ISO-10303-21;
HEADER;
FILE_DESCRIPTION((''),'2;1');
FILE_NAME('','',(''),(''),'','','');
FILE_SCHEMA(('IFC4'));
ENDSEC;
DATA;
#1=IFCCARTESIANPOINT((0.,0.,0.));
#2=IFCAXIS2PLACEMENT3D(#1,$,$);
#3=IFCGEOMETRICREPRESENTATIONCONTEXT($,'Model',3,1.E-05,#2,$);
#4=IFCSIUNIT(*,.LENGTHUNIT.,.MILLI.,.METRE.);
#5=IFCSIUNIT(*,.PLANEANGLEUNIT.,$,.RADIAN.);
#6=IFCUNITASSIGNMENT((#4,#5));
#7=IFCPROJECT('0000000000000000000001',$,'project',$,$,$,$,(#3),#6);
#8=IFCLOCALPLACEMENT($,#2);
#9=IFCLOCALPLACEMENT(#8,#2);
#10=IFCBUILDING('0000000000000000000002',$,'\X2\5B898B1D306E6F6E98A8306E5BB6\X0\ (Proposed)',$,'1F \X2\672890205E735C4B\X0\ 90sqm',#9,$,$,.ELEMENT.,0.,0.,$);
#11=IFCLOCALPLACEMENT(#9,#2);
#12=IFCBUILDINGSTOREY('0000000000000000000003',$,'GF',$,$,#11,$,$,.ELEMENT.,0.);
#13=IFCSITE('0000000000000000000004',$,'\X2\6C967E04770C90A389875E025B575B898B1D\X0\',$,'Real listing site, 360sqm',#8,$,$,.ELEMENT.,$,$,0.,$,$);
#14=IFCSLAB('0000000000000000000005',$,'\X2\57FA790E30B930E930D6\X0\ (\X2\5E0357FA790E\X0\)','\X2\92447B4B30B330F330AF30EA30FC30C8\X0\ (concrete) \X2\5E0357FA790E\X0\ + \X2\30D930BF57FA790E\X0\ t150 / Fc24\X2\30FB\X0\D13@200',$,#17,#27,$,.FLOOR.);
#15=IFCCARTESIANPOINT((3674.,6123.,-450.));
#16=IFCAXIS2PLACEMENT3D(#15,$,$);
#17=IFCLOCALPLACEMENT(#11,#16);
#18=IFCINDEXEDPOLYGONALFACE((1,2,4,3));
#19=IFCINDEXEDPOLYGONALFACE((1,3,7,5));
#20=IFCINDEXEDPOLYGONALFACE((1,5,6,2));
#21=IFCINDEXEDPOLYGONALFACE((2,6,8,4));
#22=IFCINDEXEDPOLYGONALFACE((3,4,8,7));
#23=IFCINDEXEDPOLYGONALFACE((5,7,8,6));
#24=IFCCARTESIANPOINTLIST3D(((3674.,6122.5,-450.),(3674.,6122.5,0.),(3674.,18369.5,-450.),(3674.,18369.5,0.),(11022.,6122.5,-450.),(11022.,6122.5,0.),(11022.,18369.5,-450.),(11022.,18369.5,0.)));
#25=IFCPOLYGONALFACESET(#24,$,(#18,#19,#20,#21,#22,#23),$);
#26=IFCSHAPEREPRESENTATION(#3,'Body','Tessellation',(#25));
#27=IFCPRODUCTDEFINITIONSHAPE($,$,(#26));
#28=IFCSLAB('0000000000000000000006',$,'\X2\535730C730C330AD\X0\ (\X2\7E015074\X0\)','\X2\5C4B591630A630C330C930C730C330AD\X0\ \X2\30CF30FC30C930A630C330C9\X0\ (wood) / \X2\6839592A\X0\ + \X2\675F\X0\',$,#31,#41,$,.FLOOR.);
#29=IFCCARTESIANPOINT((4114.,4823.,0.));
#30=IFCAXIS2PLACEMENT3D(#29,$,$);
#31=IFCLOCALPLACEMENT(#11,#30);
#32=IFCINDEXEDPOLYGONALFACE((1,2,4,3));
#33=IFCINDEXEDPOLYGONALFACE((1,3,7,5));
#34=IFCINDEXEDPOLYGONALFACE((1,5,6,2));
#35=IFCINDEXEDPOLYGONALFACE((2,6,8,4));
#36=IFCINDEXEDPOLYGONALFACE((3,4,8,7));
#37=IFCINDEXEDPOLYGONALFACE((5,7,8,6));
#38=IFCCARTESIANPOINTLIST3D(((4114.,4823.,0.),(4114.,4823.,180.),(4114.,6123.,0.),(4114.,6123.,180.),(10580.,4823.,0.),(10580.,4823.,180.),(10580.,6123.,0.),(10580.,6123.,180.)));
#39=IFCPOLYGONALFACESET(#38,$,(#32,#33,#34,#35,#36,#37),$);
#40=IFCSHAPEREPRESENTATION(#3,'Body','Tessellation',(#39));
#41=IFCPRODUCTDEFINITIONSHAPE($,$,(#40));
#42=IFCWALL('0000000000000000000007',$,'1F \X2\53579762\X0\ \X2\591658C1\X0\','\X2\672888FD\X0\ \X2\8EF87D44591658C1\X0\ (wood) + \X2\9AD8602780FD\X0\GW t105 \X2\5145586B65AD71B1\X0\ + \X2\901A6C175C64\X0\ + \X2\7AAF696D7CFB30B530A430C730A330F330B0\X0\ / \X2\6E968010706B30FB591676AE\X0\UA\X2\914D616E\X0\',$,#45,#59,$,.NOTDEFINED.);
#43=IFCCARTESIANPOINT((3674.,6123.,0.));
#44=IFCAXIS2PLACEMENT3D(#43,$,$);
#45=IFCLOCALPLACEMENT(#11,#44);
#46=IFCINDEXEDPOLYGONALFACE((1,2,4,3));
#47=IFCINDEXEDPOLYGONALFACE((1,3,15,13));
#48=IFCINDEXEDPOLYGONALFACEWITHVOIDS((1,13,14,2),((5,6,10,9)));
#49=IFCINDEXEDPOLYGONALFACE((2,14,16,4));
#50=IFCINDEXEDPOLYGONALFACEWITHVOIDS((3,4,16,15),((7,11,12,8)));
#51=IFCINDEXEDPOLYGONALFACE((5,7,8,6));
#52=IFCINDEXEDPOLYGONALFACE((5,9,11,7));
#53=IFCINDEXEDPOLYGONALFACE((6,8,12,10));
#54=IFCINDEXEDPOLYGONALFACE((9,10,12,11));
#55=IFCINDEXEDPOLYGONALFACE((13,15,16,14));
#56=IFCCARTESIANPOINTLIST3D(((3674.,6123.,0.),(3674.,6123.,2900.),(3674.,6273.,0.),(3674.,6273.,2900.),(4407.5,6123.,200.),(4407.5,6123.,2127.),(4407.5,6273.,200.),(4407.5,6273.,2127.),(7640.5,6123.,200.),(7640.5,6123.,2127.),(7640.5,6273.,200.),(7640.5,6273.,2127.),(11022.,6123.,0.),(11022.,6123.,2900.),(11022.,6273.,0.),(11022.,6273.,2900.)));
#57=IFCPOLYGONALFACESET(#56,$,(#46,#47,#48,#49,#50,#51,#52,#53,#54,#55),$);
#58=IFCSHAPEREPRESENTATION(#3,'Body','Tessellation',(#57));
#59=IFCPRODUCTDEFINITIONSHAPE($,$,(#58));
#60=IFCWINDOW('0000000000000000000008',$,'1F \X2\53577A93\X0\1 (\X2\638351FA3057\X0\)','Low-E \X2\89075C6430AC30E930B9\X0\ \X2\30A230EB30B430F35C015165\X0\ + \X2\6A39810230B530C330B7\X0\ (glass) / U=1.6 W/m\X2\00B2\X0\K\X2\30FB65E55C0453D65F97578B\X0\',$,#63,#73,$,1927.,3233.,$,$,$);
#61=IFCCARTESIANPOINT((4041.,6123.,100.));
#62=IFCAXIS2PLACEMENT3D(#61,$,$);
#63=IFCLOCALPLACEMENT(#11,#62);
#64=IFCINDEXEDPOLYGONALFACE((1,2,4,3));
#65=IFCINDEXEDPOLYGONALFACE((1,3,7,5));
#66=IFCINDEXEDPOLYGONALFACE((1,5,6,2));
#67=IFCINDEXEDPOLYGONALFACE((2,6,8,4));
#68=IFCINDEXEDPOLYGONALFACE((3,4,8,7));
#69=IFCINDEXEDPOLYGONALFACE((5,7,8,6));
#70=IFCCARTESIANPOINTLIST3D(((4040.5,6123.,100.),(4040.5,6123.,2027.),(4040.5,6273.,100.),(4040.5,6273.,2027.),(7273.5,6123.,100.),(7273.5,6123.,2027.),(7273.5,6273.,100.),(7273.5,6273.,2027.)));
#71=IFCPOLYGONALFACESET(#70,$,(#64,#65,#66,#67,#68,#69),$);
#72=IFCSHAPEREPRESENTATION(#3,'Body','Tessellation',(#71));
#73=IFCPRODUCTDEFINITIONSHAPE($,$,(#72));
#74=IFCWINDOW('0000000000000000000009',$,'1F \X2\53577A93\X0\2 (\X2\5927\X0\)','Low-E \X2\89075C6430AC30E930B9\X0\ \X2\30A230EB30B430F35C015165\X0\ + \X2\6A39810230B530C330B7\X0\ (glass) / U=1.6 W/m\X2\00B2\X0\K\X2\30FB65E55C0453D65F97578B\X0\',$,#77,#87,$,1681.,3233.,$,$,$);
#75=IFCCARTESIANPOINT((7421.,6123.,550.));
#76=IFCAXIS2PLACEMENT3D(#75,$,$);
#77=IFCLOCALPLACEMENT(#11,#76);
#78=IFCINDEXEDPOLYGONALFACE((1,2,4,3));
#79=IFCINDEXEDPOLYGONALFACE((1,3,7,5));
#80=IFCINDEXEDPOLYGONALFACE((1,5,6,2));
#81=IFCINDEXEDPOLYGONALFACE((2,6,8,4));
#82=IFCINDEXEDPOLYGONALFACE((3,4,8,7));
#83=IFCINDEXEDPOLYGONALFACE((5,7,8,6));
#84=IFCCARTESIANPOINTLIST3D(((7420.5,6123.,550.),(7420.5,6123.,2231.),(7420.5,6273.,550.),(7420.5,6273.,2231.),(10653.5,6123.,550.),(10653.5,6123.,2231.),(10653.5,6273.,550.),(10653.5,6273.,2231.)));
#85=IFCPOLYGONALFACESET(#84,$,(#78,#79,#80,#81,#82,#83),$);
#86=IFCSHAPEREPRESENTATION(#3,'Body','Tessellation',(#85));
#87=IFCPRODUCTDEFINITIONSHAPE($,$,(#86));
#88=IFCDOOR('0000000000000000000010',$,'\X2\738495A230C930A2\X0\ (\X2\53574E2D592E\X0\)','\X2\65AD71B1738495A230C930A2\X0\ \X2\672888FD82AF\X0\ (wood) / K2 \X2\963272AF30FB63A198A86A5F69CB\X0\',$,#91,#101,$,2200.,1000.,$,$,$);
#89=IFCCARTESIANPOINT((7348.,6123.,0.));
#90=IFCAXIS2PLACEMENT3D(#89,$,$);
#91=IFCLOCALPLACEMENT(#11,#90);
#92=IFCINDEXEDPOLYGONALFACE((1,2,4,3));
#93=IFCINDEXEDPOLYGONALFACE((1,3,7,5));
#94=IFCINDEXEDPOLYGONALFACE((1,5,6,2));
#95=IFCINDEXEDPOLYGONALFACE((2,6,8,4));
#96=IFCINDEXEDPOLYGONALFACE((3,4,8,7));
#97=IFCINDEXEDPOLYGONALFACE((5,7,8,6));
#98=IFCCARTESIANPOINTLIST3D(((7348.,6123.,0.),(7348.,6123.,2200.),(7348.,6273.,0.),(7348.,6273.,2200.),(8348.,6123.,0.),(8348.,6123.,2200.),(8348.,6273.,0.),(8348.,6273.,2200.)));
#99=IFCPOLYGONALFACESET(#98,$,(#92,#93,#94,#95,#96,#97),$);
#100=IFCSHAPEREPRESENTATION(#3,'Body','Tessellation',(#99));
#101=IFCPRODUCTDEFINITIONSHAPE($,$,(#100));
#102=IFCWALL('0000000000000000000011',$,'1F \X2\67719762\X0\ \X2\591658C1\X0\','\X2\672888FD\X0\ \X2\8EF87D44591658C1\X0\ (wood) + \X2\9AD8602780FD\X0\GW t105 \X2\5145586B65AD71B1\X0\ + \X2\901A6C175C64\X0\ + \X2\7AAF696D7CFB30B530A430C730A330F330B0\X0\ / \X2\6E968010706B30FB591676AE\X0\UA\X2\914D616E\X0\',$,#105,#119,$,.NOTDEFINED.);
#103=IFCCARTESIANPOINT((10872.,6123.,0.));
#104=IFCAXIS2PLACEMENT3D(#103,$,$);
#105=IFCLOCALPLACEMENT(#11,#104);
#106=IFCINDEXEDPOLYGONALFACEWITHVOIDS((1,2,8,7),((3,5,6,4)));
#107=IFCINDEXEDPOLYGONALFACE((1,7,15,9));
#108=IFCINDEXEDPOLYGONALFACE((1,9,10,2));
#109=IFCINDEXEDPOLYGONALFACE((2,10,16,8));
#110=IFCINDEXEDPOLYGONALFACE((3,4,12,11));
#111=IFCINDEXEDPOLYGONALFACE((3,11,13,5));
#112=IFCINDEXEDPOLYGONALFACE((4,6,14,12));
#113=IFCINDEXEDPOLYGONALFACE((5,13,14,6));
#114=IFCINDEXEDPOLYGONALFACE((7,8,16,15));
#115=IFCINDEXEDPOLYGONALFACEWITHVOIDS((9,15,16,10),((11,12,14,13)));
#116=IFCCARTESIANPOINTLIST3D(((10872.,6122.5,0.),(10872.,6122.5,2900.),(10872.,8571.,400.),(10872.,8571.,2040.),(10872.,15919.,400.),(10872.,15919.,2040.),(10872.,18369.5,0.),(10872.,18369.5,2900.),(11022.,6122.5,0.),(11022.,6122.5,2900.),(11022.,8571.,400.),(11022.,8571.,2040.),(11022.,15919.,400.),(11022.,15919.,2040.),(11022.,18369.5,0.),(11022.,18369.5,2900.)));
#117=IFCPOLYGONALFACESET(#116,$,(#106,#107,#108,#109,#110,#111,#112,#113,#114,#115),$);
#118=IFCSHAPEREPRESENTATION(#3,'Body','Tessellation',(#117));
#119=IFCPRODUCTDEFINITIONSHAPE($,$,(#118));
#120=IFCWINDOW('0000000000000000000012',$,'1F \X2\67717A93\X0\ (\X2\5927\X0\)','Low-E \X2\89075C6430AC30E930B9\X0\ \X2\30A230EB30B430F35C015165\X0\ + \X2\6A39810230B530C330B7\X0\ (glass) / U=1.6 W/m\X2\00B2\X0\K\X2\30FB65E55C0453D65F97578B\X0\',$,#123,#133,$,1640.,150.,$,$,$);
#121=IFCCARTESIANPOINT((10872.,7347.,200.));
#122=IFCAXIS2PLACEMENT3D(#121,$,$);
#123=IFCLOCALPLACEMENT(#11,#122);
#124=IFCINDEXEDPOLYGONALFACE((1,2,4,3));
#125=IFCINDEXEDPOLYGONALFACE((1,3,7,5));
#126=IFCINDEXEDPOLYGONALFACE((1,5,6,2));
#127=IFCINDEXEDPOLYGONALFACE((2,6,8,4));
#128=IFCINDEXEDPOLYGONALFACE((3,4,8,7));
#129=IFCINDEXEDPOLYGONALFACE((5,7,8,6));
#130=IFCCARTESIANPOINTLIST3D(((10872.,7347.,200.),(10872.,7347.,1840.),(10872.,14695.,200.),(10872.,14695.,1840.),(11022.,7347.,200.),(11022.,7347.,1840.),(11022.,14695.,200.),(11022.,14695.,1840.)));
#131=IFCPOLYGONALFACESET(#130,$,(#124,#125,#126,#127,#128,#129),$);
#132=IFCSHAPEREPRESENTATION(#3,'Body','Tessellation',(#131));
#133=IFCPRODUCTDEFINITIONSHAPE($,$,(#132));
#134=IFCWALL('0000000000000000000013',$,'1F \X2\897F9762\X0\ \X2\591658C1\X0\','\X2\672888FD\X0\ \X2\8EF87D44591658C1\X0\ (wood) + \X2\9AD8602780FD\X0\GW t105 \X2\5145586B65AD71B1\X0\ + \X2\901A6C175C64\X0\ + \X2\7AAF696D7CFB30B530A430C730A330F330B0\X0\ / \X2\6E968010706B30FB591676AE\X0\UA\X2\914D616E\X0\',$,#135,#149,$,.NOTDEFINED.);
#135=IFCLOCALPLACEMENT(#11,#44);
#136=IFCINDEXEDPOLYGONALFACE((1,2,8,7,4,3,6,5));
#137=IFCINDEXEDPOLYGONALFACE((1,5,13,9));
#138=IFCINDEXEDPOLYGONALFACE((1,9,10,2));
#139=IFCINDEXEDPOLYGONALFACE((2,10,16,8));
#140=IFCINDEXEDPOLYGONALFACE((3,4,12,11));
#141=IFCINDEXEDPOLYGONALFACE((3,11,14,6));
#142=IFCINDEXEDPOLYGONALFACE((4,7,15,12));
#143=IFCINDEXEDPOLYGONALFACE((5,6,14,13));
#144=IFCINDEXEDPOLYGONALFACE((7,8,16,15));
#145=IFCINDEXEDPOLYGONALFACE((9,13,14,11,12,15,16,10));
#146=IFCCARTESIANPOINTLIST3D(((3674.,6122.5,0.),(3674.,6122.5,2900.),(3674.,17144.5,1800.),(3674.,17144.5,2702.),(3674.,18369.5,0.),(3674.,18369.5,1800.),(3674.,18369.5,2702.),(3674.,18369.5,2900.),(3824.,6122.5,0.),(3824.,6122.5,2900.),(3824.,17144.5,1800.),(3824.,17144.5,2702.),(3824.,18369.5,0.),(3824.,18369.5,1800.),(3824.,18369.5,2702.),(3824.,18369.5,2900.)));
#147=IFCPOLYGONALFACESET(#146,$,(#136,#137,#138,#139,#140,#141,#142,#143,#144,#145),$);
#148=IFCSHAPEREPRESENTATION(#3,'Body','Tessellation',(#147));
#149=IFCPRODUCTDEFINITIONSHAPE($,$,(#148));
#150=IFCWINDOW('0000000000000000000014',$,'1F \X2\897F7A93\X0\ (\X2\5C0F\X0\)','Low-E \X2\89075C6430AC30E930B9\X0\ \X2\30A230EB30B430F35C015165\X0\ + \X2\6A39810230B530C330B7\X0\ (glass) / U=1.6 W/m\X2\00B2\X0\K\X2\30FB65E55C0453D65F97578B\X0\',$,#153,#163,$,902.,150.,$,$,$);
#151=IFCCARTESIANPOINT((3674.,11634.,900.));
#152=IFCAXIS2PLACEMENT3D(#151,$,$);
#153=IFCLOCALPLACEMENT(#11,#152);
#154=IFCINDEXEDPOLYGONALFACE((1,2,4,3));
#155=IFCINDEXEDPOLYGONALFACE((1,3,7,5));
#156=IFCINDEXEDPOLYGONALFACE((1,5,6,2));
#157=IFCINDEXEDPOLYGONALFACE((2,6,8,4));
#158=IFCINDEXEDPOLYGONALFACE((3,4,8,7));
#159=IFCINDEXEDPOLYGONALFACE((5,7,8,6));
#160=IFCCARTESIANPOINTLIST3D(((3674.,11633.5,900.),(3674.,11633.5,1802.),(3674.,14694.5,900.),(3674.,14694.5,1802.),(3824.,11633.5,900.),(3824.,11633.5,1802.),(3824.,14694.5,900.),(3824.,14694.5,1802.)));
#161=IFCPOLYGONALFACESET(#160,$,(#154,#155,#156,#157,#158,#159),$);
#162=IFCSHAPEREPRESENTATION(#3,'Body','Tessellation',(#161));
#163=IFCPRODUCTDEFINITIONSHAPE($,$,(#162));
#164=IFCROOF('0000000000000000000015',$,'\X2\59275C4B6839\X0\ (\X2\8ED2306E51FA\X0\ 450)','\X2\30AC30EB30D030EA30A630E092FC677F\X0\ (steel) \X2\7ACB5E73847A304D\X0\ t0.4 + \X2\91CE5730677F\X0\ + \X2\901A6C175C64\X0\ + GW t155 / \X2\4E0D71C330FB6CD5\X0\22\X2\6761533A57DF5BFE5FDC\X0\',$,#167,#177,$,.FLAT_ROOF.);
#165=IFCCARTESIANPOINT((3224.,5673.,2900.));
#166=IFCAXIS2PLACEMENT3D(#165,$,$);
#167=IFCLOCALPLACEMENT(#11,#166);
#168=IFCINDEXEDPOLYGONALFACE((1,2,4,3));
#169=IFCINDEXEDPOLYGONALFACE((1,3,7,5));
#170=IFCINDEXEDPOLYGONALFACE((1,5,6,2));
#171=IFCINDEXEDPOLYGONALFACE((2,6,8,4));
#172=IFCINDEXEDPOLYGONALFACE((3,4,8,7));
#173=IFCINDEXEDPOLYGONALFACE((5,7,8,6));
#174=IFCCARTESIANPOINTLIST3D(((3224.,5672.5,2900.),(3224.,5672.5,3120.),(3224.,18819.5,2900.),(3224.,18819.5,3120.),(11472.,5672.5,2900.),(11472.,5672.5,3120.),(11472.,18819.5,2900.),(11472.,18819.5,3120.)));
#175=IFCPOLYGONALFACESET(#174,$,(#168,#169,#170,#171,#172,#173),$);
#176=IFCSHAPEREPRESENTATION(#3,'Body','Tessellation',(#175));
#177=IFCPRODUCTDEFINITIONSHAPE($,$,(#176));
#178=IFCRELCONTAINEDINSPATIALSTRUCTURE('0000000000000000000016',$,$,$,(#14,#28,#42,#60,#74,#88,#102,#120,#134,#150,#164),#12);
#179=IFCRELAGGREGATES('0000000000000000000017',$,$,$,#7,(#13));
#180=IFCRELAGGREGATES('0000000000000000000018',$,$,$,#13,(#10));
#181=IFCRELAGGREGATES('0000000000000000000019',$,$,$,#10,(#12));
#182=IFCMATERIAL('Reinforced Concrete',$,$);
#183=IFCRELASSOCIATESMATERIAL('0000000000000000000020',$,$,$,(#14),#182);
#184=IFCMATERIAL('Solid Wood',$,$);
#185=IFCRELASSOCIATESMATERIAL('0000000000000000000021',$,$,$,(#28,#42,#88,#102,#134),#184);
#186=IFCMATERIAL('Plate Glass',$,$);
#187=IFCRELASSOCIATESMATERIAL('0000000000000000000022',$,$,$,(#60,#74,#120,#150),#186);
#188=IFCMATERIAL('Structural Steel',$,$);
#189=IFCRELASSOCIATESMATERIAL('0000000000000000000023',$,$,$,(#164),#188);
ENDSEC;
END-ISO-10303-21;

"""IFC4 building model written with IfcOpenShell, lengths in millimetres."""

from ifc_helpers import new_model, si_unit, frame, frame_2d, origin, place, context, project, spatial, rectangle, extrude, material, element, fill, save


model = new_model("IFC4")

# Units and contexts
model_context = context("Model", 3, precision=1e-05, world=origin())
ifc_project = project(units=[si_unit("LENGTHUNIT", "METRE", prefix="MILLI"), si_unit("PLANEANGLEUNIT", "RADIAN")], contexts=[model_context])

# Site, building, storey
site_placement = place(None, origin())
site = spatial("IfcSite", under=ifc_project, at=site_placement, Name="沖縄県那覇市字安謝", ObjectType="Real listing site, 360sqm", CompositionType="ELEMENT", RefElevation=0.0)
building_placement = place(site_placement, origin())
building = spatial("IfcBuilding", under=site, at=building_placement, Name="安謝の潮風の家 (Proposed)", ObjectType="1F 木造平屋 90sqm", CompositionType="ELEMENT", ElevationOfRefHeight=0.0, ElevationOfTerrain=0.0)
storey_placement = place(building_placement, origin())
storey = spatial("IfcBuildingStorey", under=building, at=storey_placement, Name="GF", CompositionType="ELEMENT", Elevation=0.0)

# Slabs
ifc_material_1 = material(Name="Reinforced Concrete")
slab_1_placement = place(storey_placement, frame((3674.0, 6123.0, -450.0)))
element("IfcSlab", 1, at=slab_1_placement, inside=storey, material=ifc_material_1, Name="基礎スラブ (布基礎)", Description="鉄筋コンクリート (concrete) 布基礎 + ベタ基礎 t150 / Fc24・D13@200", PredefinedType="FLOOR", context=model_context, shape_type="SweptSolid", body=[
    extrude(rectangle(XDim=7348.0, YDim=12247.0, at=frame_2d((3674.0, 6123.0))), frame((3674.0, 6123.0, -450.0)), (0.0, 0.0, 1.0), 450.0),
])
ifc_material_2 = material(Name="Solid Wood")
slab_2_placement = place(storey_placement, frame((4114.0, 4823.0, 0.0)))
element("IfcSlab", 2, at=slab_2_placement, inside=storey, material=ifc_material_2, Name="南デッキ (縁側)", Description="屋外ウッドデッキ ハードウッド (wood) / 根太 + 束", PredefinedType="FLOOR", context=model_context, shape_type="SweptSolid", body=[
    extrude(rectangle(XDim=6466.0, YDim=1300.0, at=frame_2d((3233.0, 650.0))), frame((4114.0, 4823.0, 0.0)), (0.0, 0.0, 1.0), 180.0),
])

# Wall, openings, windows, door
wall_1_placement = place(storey_placement, frame((3674.0, 6123.0, 0.0)))
wall_1 = element("IfcWall", 3, at=wall_1_placement, inside=storey, material=ifc_material_2, Name="1F 南面 外壁", Description="木製 軸組外壁 (wood) + 高性能GW t105 充填断熱 + 通気層 + 窯業系サイディング / 準耐火・外皮UA配慮", PredefinedType="NOTDEFINED", context=model_context, shape_type="SweptSolid", body=[
    extrude(rectangle(XDim=7348.0, YDim=150.0, at=frame_2d((3674.0, 75.0))), frame((3674.0, 6123.0, 0.0)), (0.0, 0.0, 1.0), 2900.0),
])
opening_1_placement = place(storey_placement, frame((4041.0, 6123.0, 100.0)))
opening_1 = element("IfcOpeningElement", 4, at=opening_1_placement, cuts=wall_1, PredefinedType="NOTDEFINED", context=model_context, shape_type="SweptSolid", body=[
    extrude(rectangle(XDim=3233.0, YDim=150.0, at=frame_2d((1616.0, 75.0))), frame((4041.0, 6123.0, 100.0)), (0.0, 0.0, 1.0), 1927.0),
])
opening_2_placement = place(storey_placement, frame((7421.0, 6123.0, 550.0)))
opening_2 = element("IfcOpeningElement", 5, at=opening_2_placement, cuts=wall_1, PredefinedType="NOTDEFINED", context=model_context, shape_type="SweptSolid", body=[
    extrude(rectangle(XDim=3233.0, YDim=150.0, at=frame_2d((1616.0, 75.0))), frame((7421.0, 6123.0, 550.0)), (0.0, 0.0, 1.0), 1681.0),
])
opening_3_placement = place(storey_placement, frame((7348.0, 6123.0, 0.0)))
opening_3 = element("IfcOpeningElement", 6, at=opening_3_placement, cuts=wall_1, PredefinedType="NOTDEFINED", context=model_context, shape_type="SweptSolid", body=[
    extrude(rectangle(XDim=1000.0, YDim=150.0, at=frame_2d((500.0, 75.0))), frame((7348.0, 6123.0, 0.0)), (0.0, 0.0, 1.0), 2200.0),
])
ifc_material_3 = material(Name="Plate Glass")
window_1_placement = place(storey_placement, frame((4041.0, 6123.0, 100.0)))
window_1 = element("IfcWindow", 7, at=window_1_placement, inside=storey, material=ifc_material_3, Name="1F 南窓1 (掃出し)", Description="Low-E 複層ガラス アルゴン封入 + 樹脂サッシ (glass) / U=1.6 W/m²K・日射取得型", OverallHeight=1927.0, OverallWidth=3233.0, context=model_context, shape_type="SweptSolid", body=[
    extrude(rectangle(XDim=3233.0, YDim=150.0, at=frame_2d((1616.0, 75.0))), frame((4041.0, 6123.0, 100.0)), (0.0, 0.0, 1.0), 1927.0),
])
fill(opening_1, window_1)
window_2_placement = place(storey_placement, frame((7421.0, 6123.0, 550.0)))
window_2 = element("IfcWindow", 8, at=window_2_placement, inside=storey, material=ifc_material_3, Name="1F 南窓2 (大)", Description="Low-E 複層ガラス アルゴン封入 + 樹脂サッシ (glass) / U=1.6 W/m²K・日射取得型", OverallHeight=1681.0, OverallWidth=3233.0, context=model_context, shape_type="SweptSolid", body=[
    extrude(rectangle(XDim=3233.0, YDim=150.0, at=frame_2d((1616.0, 75.0))), frame((7421.0, 6123.0, 550.0)), (0.0, 0.0, 1.0), 1681.0),
])
fill(opening_2, window_2)
door_placement = place(storey_placement, frame((7348.0, 6123.0, 0.0)))
door = element("IfcDoor", 9, at=door_placement, inside=storey, material=ifc_material_2, Name="玄関ドア (南中央)", Description="断熱玄関ドア 木製芯 (wood) / K2 防犯・採風機構", OverallHeight=2200.0, OverallWidth=1000.0, context=model_context, shape_type="SweptSolid", body=[
    extrude(rectangle(XDim=1000.0, YDim=150.0, at=frame_2d((500.0, 75.0))), frame((7348.0, 6123.0, 0.0)), (0.0, 0.0, 1.0), 2200.0),
])
fill(opening_3, door)

# Walls, openings, windows
wall_2_placement = place(storey_placement, frame((10872.0, 6123.0, 0.0)))
wall_2 = element("IfcWall", 10, at=wall_2_placement, inside=storey, material=ifc_material_2, Name="1F 東面 外壁", Description="木製 軸組外壁 (wood) + 高性能GW t105 充填断熱 + 通気層 + 窯業系サイディング / 準耐火・外皮UA配慮", PredefinedType="NOTDEFINED", context=model_context, shape_type="SweptSolid", body=[
    extrude(rectangle(XDim=150.0, YDim=12247.0, at=frame_2d((75.0, 6123.0))), frame((10872.0, 6123.0, 0.0)), (0.0, 0.0, 1.0), 2900.0),
])
opening_4_placement = place(storey_placement, frame((10872.0, 7347.0, 200.0)))
opening_4 = element("IfcOpeningElement", 11, at=opening_4_placement, cuts=wall_2, PredefinedType="NOTDEFINED", context=model_context, shape_type="SweptSolid", body=[
    extrude(rectangle(XDim=150.0, YDim=7348.0, at=frame_2d((75.0, 3674.0))), frame((10872.0, 7347.0, 200.0)), (0.0, 0.0, 1.0), 1640.0),
])
window_3_placement = place(storey_placement, frame((10872.0, 7347.0, 200.0)))
window_3 = element("IfcWindow", 12, at=window_3_placement, inside=storey, material=ifc_material_3, Name="1F 東窓 (大)", Description="Low-E 複層ガラス アルゴン封入 + 樹脂サッシ (glass) / U=1.6 W/m²K・日射取得型", OverallHeight=1640.0, OverallWidth=150.0, context=model_context, shape_type="SweptSolid", body=[
    extrude(rectangle(XDim=150.0, YDim=7348.0, at=frame_2d((75.0, 3674.0))), frame((10872.0, 7347.0, 200.0)), (0.0, 0.0, 1.0), 1640.0),
])
fill(opening_4, window_3)
wall_3_placement = place(storey_placement, frame((3674.0, 6123.0, 0.0)))
wall_3 = element("IfcWall", 13, at=wall_3_placement, inside=storey, material=ifc_material_2, Name="1F 西面 外壁", Description="木製 軸組外壁 (wood) + 高性能GW t105 充填断熱 + 通気層 + 窯業系サイディング / 準耐火・外皮UA配慮", PredefinedType="NOTDEFINED", context=model_context, shape_type="SweptSolid", body=[
    extrude(rectangle(XDim=150.0, YDim=12247.0, at=frame_2d((75.0, 6123.0))), frame((3674.0, 6123.0, 0.0)), (0.0, 0.0, 1.0), 2900.0),
])
opening_5_placement = place(storey_placement, frame((3674.0, 11634.0, 900.0)))
opening_5 = element("IfcOpeningElement", 14, at=opening_5_placement, cuts=wall_3, PredefinedType="NOTDEFINED", context=model_context, shape_type="SweptSolid", body=[
    extrude(rectangle(XDim=150.0, YDim=3061.0, at=frame_2d((75.0, 1530.0))), frame((3674.0, 11634.0, 900.0)), (0.0, 0.0, 1.0), 902.0),
])
window_4_placement = place(storey_placement, frame((3674.0, 11634.0, 900.0)))
window_4 = element("IfcWindow", 15, at=window_4_placement, inside=storey, material=ifc_material_3, Name="1F 西窓 (小)", Description="Low-E 複層ガラス アルゴン封入 + 樹脂サッシ (glass) / U=1.6 W/m²K・日射取得型", OverallHeight=902.0, OverallWidth=150.0, context=model_context, shape_type="SweptSolid", body=[
    extrude(rectangle(XDim=150.0, YDim=3061.0, at=frame_2d((75.0, 1530.0))), frame((3674.0, 11634.0, 900.0)), (0.0, 0.0, 1.0), 902.0),
])
fill(opening_5, window_4)

# Roof
ifc_material_4 = material(Name="Structural Steel")
roof_placement = place(storey_placement, frame((3224.0, 5673.0, 2900.0)))
element("IfcRoof", 16, at=roof_placement, inside=storey, material=ifc_material_4, Name="大屋根 (軒の出 450)", Description="ガルバリウム鋼板 (steel) 立平葺き t0.4 + 野地板 + 通気層 + GW t155 / 不燃・法22条区域対応", PredefinedType="FLAT_ROOF", context=model_context, shape_type="SweptSolid", body=[
    extrude(rectangle(XDim=8248.0, YDim=13147.0, at=frame_2d((4124.0, 6573.0))), frame((3224.0, 5673.0, 2900.0)), (0.0, 0.0, 1.0), 220.0),
])

save(model, "model.ifc")
